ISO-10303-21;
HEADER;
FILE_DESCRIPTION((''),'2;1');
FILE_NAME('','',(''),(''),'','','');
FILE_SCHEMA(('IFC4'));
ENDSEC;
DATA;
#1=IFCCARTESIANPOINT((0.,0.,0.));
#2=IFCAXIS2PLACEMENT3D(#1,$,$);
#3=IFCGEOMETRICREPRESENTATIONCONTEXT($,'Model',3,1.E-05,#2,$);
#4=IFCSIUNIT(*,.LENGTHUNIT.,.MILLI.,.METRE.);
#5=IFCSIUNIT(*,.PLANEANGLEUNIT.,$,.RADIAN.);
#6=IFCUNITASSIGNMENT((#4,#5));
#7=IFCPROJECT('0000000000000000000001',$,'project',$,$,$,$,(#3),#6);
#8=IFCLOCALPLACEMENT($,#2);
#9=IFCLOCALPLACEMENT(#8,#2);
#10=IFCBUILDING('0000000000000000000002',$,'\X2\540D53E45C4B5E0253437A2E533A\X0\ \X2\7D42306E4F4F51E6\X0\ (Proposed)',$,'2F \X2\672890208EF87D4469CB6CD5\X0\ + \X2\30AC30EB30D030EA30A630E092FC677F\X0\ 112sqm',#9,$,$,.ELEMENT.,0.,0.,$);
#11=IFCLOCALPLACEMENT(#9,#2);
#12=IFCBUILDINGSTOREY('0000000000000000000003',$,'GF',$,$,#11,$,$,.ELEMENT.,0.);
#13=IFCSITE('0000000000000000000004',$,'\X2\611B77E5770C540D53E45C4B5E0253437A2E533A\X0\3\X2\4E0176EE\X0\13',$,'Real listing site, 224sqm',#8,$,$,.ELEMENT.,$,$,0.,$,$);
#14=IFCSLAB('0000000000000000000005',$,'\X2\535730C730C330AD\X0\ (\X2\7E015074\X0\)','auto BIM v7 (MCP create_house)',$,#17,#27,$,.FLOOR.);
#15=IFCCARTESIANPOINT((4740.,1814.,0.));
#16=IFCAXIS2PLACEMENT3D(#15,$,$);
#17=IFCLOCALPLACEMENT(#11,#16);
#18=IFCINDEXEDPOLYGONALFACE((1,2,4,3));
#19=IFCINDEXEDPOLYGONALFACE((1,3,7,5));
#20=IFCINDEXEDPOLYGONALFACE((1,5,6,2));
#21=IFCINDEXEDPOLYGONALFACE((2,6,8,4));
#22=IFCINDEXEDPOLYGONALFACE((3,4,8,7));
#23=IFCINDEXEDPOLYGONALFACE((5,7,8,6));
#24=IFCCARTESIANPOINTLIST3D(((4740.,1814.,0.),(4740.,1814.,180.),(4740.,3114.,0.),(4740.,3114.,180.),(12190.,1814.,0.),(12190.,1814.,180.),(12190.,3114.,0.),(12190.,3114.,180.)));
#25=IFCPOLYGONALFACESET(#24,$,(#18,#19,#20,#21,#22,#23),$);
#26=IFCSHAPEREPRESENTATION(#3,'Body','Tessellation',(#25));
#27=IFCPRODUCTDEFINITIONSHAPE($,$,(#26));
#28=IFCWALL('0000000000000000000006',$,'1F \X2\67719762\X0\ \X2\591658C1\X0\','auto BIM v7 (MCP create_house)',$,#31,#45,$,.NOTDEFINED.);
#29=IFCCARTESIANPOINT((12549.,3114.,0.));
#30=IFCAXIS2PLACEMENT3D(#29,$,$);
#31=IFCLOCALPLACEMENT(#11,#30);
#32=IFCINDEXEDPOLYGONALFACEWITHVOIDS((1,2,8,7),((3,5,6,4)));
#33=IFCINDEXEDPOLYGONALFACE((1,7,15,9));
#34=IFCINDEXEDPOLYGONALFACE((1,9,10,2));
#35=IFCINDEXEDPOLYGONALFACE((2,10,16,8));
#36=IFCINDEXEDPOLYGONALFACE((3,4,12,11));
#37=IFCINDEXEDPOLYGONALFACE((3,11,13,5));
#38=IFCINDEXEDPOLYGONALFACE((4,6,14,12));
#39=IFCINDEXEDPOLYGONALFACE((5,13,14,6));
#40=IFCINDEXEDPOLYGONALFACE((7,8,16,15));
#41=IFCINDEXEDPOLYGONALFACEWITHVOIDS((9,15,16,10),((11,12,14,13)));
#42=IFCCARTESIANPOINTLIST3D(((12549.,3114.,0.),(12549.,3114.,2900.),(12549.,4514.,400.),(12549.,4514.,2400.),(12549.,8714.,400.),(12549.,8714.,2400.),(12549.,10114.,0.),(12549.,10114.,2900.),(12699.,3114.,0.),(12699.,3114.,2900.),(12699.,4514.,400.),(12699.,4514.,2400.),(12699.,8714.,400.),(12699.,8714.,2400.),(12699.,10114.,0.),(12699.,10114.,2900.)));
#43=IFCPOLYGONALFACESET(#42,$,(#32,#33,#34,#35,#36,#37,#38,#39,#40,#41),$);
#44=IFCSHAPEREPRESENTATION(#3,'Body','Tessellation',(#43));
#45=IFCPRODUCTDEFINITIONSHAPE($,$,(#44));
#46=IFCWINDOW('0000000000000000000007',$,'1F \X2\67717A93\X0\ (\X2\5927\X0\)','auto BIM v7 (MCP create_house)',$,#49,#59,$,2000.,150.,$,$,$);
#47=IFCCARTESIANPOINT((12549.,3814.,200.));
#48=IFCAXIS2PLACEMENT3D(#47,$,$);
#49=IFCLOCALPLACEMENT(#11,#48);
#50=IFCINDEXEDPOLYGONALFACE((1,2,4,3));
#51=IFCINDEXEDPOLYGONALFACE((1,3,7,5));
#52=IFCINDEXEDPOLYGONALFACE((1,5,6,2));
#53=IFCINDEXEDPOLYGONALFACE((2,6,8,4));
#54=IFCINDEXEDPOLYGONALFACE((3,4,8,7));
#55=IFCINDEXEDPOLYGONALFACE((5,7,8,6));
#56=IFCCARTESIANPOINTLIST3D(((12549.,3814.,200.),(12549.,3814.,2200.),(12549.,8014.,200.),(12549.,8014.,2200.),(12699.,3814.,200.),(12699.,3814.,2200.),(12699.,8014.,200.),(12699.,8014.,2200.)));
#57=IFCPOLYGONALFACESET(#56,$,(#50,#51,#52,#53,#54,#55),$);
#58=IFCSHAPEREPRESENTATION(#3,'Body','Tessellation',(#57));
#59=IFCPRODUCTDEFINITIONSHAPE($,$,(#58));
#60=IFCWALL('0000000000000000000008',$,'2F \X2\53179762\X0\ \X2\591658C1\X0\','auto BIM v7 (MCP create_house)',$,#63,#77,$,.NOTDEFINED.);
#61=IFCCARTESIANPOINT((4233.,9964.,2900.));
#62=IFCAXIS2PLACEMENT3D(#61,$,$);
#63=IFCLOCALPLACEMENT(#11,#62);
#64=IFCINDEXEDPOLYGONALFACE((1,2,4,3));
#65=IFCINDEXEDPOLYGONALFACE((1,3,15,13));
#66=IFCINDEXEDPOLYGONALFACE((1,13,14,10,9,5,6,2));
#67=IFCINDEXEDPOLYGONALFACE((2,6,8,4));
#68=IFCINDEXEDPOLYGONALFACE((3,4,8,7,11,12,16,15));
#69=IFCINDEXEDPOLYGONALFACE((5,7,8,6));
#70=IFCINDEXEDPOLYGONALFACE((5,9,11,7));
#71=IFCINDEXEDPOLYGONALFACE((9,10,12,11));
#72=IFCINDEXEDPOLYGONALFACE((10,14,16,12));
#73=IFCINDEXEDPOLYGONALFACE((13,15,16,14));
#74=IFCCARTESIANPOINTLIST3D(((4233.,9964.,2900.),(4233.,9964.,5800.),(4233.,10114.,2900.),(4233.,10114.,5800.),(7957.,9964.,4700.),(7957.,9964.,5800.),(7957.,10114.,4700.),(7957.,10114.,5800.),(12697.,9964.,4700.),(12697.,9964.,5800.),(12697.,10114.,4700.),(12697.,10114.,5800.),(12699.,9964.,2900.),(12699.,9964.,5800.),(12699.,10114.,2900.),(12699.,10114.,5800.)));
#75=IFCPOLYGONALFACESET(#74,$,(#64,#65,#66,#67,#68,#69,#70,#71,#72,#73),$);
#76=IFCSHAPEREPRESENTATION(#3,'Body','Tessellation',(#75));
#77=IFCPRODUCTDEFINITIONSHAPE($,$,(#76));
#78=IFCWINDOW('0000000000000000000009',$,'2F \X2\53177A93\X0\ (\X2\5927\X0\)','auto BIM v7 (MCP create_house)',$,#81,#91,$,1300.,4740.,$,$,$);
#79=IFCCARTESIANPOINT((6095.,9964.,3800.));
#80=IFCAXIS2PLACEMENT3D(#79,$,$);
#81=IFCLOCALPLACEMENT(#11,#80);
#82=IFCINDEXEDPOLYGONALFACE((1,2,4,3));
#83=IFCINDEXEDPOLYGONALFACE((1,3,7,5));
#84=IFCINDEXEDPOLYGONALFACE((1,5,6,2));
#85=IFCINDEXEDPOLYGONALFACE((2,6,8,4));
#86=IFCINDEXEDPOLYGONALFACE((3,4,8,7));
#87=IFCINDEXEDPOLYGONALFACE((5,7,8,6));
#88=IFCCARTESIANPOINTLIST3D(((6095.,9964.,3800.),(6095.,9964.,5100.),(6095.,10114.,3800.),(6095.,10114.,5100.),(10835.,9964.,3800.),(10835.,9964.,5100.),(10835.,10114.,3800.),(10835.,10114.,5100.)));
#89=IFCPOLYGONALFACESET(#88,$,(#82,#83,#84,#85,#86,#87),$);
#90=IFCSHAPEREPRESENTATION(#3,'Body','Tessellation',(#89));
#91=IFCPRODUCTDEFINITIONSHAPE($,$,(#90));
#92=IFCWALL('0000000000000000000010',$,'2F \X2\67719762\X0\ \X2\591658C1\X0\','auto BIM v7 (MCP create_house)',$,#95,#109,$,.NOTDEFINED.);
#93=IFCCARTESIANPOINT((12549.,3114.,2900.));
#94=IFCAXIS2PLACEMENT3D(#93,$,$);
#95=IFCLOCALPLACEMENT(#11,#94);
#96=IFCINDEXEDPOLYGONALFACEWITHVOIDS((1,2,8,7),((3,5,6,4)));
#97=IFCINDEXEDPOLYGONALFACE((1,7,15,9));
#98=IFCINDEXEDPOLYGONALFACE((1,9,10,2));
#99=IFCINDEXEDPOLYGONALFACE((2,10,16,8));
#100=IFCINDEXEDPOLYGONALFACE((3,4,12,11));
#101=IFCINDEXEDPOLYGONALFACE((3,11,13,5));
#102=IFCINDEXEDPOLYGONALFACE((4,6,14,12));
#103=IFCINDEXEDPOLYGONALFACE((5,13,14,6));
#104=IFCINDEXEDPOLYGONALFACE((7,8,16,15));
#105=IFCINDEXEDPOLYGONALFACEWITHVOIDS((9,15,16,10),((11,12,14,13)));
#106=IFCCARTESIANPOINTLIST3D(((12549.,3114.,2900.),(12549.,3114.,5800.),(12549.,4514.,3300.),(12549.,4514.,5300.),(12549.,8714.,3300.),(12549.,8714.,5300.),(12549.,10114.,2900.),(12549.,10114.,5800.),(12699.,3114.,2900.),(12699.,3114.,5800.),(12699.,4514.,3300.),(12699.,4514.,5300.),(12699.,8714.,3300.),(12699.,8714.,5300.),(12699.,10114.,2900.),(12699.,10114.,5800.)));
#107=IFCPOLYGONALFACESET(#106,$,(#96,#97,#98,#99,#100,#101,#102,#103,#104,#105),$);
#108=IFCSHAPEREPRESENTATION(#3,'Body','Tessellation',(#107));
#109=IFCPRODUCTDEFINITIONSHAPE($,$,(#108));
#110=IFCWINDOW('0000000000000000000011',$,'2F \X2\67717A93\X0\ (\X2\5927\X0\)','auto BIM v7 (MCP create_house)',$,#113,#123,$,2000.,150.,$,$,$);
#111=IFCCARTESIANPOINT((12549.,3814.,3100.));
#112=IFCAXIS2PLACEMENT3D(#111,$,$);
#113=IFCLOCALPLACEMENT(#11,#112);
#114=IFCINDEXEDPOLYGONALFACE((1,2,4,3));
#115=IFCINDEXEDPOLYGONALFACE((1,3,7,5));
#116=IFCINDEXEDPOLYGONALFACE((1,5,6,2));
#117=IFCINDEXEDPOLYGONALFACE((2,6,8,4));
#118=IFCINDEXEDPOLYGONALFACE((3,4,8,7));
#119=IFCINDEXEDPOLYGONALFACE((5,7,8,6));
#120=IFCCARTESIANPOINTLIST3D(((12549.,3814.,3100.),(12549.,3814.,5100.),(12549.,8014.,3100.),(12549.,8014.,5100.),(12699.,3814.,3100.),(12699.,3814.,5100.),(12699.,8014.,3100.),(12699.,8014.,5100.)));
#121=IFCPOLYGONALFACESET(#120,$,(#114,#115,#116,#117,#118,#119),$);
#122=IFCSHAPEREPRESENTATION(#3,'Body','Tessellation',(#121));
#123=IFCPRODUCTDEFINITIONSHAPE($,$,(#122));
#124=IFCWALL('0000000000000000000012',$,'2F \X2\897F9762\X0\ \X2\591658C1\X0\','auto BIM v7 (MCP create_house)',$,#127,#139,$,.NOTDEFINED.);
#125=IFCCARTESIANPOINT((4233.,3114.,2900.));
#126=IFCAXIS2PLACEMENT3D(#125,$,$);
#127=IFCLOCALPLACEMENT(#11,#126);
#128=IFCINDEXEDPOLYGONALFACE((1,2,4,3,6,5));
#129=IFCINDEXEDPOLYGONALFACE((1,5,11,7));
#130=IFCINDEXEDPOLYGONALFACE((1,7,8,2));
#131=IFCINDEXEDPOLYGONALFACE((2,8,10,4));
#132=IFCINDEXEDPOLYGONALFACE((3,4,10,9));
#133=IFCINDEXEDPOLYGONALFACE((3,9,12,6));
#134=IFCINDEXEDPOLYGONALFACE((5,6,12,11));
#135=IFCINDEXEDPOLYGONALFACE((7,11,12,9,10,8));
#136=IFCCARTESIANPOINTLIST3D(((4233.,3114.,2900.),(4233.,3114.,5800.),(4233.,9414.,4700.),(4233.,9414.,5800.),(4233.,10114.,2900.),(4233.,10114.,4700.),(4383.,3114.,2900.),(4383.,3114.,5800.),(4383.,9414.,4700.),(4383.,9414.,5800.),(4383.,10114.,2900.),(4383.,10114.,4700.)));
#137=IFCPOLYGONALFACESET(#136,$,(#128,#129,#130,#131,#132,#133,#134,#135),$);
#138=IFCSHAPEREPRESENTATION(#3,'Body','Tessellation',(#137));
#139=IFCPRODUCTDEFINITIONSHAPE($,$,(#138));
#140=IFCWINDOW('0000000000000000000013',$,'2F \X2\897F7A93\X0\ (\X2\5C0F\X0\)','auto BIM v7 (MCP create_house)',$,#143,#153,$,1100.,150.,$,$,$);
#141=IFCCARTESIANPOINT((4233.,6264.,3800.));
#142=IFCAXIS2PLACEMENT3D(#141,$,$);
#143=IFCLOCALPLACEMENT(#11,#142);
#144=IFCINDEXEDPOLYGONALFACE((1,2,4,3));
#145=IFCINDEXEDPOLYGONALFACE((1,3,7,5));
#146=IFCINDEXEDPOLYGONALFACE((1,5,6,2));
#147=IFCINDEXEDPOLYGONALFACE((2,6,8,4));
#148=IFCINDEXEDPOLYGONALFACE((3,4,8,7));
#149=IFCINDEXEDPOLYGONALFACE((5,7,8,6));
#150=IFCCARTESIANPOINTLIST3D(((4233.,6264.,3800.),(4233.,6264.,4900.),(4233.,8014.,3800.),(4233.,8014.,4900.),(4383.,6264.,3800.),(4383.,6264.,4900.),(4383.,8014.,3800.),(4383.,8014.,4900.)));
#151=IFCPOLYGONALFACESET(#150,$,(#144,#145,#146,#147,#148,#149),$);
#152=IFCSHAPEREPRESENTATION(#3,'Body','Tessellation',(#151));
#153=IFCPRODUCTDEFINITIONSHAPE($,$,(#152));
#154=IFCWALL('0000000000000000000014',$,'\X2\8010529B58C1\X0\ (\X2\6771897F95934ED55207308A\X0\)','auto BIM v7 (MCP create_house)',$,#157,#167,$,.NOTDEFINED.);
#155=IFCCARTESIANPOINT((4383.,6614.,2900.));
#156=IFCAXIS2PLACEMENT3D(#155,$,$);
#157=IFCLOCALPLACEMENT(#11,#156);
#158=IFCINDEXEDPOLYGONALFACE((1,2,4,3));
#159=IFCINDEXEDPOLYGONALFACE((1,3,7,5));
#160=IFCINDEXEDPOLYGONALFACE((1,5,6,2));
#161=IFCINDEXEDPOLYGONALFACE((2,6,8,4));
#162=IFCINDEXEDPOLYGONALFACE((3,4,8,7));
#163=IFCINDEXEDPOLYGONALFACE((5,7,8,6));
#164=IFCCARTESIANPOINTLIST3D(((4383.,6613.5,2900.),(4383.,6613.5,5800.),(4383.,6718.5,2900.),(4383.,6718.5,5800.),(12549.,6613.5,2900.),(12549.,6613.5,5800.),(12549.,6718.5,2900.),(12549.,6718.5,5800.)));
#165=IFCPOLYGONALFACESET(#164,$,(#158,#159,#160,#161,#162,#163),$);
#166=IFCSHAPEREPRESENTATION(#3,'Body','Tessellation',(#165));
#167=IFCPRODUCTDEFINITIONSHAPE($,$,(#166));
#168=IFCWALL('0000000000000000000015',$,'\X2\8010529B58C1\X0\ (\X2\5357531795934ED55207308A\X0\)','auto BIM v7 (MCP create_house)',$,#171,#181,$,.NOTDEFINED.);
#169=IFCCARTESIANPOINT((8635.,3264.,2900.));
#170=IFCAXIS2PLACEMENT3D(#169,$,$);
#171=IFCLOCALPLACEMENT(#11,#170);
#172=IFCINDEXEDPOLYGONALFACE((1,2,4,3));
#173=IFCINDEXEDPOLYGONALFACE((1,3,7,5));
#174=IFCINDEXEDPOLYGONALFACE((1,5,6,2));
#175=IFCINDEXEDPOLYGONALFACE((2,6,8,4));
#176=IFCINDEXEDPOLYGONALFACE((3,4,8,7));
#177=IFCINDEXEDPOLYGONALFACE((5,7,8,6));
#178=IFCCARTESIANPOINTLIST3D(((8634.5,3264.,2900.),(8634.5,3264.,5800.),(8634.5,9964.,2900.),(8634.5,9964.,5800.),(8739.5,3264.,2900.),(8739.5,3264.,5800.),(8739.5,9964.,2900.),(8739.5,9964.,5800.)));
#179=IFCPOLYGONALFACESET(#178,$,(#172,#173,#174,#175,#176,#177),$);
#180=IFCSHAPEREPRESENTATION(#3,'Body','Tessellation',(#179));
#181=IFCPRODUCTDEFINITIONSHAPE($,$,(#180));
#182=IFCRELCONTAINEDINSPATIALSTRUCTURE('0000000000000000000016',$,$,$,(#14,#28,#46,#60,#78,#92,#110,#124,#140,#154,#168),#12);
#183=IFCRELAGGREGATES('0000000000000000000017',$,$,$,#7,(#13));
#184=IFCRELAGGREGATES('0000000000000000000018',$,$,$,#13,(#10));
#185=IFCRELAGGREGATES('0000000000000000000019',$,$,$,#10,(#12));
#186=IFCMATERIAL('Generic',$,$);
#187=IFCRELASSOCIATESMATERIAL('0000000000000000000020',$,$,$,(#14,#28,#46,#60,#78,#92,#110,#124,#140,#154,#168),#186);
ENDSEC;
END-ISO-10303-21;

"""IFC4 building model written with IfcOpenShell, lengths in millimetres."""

from ifc_helpers import new_model, si_unit, frame, frame_2d, origin, place, context, project, spatial, rectangle, extrude, material, element, fill, save


model = new_model("IFC4")

# Units and contexts
model_context = context("Model", 3, precision=1e-05, world=origin())
ifc_project = project(units=[si_unit("LENGTHUNIT", "METRE", prefix="MILLI"), si_unit("PLANEANGLEUNIT", "RADIAN")], contexts=[model_context])

# Site, building, storey
site_placement = place(None, origin())
site = spatial("IfcSite", under=ifc_project, at=site_placement, Name="愛知県名古屋市千種区3丁目13", ObjectType="Real listing site, 224sqm", CompositionType="ELEMENT", RefElevation=0.0)
building_placement = place(site_placement, origin())
building = spatial("IfcBuilding", under=site, at=building_placement, Name="名古屋市千種区 終の住処 (Proposed)", ObjectType="2F 木造軸組構法 + ガルバリウム鋼板 112sqm", CompositionType="ELEMENT", ElevationOfRefHeight=0.0, ElevationOfTerrain=0.0)
storey_placement = place(building_placement, origin())
storey = spatial("IfcBuildingStorey", under=building, at=storey_placement, Name="GF", CompositionType="ELEMENT", Elevation=0.0)

# Slab
ifc_material = material(Name="Generic")
slab_placement = place(storey_placement, frame((4740.0, 1814.0, 0.0)))
element("IfcSlab", 1, at=slab_placement, inside=storey, material=ifc_material, Name="南デッキ (縁側)", Description="auto BIM v7 (MCP create_house)", PredefinedType="FLOOR", context=model_context, shape_type="SweptSolid", body=[
    extrude(rectangle(XDim=7450.0, YDim=1300.0, at=frame_2d((3725.0, 650.0))), frame((4740.0, 1814.0, 0.0)), (0.0, 0.0, 1.0), 180.0),
])

# Wall, opening, window
wall_1_placement = place(storey_placement, frame((12549.0, 3114.0, 0.0)))
wall_1 = element("IfcWall", 2, at=wall_1_placement, inside=storey, material=ifc_material, Name="1F 東面 外壁", Description="auto BIM v7 (MCP create_house)", PredefinedType="NOTDEFINED", context=model_context, shape_type="SweptSolid", body=[
    extrude(rectangle(XDim=150.0, YDim=7000.0, at=frame_2d((75.0, 3500.0))), frame((12549.0, 3114.0, 0.0)), (0.0, 0.0, 1.0), 2900.0),
])
opening_1_placement = place(storey_placement, frame((12549.0, 3814.0, 200.0)))
opening_1 = element("IfcOpeningElement", 3, at=opening_1_placement, cuts=wall_1, PredefinedType="NOTDEFINED", context=model_context, shape_type="SweptSolid", body=[
    extrude(rectangle(XDim=150.0, YDim=4200.0, at=frame_2d((75.0, 2100.0))), frame((12549.0, 3814.0, 200.0)), (0.0, 0.0, 1.0), 2000.0),
])
window_1_placement = place(storey_placement, frame((12549.0, 3814.0, 200.0)))
window_1 = element("IfcWindow", 4, at=window_1_placement, inside=storey, material=ifc_material, Name="1F 東窓 (大)", Description="auto BIM v7 (MCP create_house)", OverallHeight=2000.0, OverallWidth=150.0, context=model_context, shape_type="SweptSolid", body=[
    extrude(rectangle(XDim=150.0, YDim=4200.0, at=frame_2d((75.0, 2100.0))), frame((12549.0, 3814.0, 200.0)), (0.0, 0.0, 1.0), 2000.0),
])
fill(opening_1, window_1)

# Walls, openings, windows
wall_2_placement = place(storey_placement, frame((4233.0, 9964.0, 2900.0)))
wall_2 = element("IfcWall", 5, at=wall_2_placement, inside=storey, material=ifc_material, Name="2F 北面 外壁", Description="auto BIM v7 (MCP create_house)", PredefinedType="NOTDEFINED", context=model_context, shape_type="SweptSolid", body=[
    extrude(rectangle(XDim=8466.0, YDim=150.0, at=frame_2d((4233.0, 75.0))), frame((4233.0, 9964.0, 2900.0)), (0.0, 0.0, 1.0), 2900.0),
])
opening_2_placement = place(storey_placement, frame((6095.0, 9964.0, 3800.0)))
opening_2 = element("IfcOpeningElement", 6, at=opening_2_placement, cuts=wall_2, PredefinedType="NOTDEFINED", context=model_context, shape_type="SweptSolid", body=[
    extrude(rectangle(XDim=4740.0, YDim=150.0, at=frame_2d((2370.0, 75.0))), frame((6095.0, 9964.0, 3800.0)), (0.0, 0.0, 1.0), 1300.0),
])
window_2_placement = place(storey_placement, frame((6095.0, 9964.0, 3800.0)))
window_2 = element("IfcWindow", 7, at=window_2_placement, inside=storey, material=ifc_material, Name="2F 北窓 (大)", Description="auto BIM v7 (MCP create_house)", OverallHeight=1300.0, OverallWidth=4740.0, context=model_context, shape_type="SweptSolid", body=[
    extrude(rectangle(XDim=4740.0, YDim=150.0, at=frame_2d((2370.0, 75.0))), frame((6095.0, 9964.0, 3800.0)), (0.0, 0.0, 1.0), 1300.0),
])
fill(opening_2, window_2)
wall_3_placement = place(storey_placement, frame((12549.0, 3114.0, 2900.0)))
wall_3 = element("IfcWall", 8, at=wall_3_placement, inside=storey, material=ifc_material, Name="2F 東面 外壁", Description="auto BIM v7 (MCP create_house)", PredefinedType="NOTDEFINED", context=model_context, shape_type="SweptSolid", body=[
    extrude(rectangle(XDim=150.0, YDim=7000.0, at=frame_2d((75.0, 3500.0))), frame((12549.0, 3114.0, 2900.0)), (0.0, 0.0, 1.0), 2900.0),
])
opening_3_placement = place(storey_placement, frame((12549.0, 3814.0, 3100.0)))
opening_3 = element("IfcOpeningElement", 9, at=opening_3_placement, cuts=wall_3, PredefinedType="NOTDEFINED", context=model_context, shape_type="SweptSolid", body=[
    extrude(rectangle(XDim=150.0, YDim=4200.0, at=frame_2d((75.0, 2100.0))), frame((12549.0, 3814.0, 3100.0)), (0.0, 0.0, 1.0), 2000.0),
])
window_3_placement = place(storey_placement, frame((12549.0, 3814.0, 3100.0)))
window_3 = element("IfcWindow", 10, at=window_3_placement, inside=storey, material=ifc_material, Name="2F 東窓 (大)", Description="auto BIM v7 (MCP create_house)", OverallHeight=2000.0, OverallWidth=150.0, context=model_context, shape_type="SweptSolid", body=[
    extrude(rectangle(XDim=150.0, YDim=4200.0, at=frame_2d((75.0, 2100.0))), frame((12549.0, 3814.0, 3100.0)), (0.0, 0.0, 1.0), 2000.0),
])
fill(opening_3, window_3)
wall_4_placement = place(storey_placement, frame((4233.0, 3114.0, 2900.0)))
wall_4 = element("IfcWall", 11, at=wall_4_placement, inside=storey, material=ifc_material, Name="2F 西面 外壁", Description="auto BIM v7 (MCP create_house)", PredefinedType="NOTDEFINED", context=model_context, shape_type="SweptSolid", body=[
    extrude(rectangle(XDim=150.0, YDim=7000.0, at=frame_2d((75.0, 3500.0))), frame((4233.0, 3114.0, 2900.0)), (0.0, 0.0, 1.0), 2900.0),
])
opening_4_placement = place(storey_placement, frame((4233.0, 6264.0, 3800.0)))
opening_4 = element("IfcOpeningElement", 12, at=opening_4_placement, cuts=wall_4, PredefinedType="NOTDEFINED", context=model_context, shape_type="SweptSolid", body=[
    extrude(rectangle(XDim=150.0, YDim=1750.0, at=frame_2d((75.0, 875.0))), frame((4233.0, 6264.0, 3800.0)), (0.0, 0.0, 1.0), 1100.0),
])
window_4_placement = place(storey_placement, frame((4233.0, 6264.0, 3800.0)))
window_4 = element("IfcWindow", 13, at=window_4_placement, inside=storey, material=ifc_material, Name="2F 西窓 (小)", Description="auto BIM v7 (MCP create_house)", OverallHeight=1100.0, OverallWidth=150.0, context=model_context, shape_type="SweptSolid", body=[
    extrude(rectangle(XDim=150.0, YDim=1750.0, at=frame_2d((75.0, 875.0))), frame((4233.0, 6264.0, 3800.0)), (0.0, 0.0, 1.0), 1100.0),
])
fill(opening_4, window_4)

# Walls
wall_5_placement = place(storey_placement, frame((4383.0, 6614.0, 2900.0)))
element("IfcWall", 14, at=wall_5_placement, inside=storey, material=ifc_material, Name="耐力壁 (東西間仕切り)", Description="auto BIM v7 (MCP create_house)", PredefinedType="NOTDEFINED", context=model_context, shape_type="SweptSolid", body=[
    extrude(rectangle(XDim=8166.0, YDim=105.0, at=frame_2d((4083.0, 52.0))), frame((4383.0, 6614.0, 2900.0)), (0.0, 0.0, 1.0), 2900.0),
])
wall_6_placement = place(storey_placement, frame((8635.0, 3264.0, 2900.0)))
element("IfcWall", 15, at=wall_6_placement, inside=storey, material=ifc_material, Name="耐力壁 (南北間仕切り)", Description="auto BIM v7 (MCP create_house)", PredefinedType="NOTDEFINED", context=model_context, shape_type="SweptSolid", body=[
    extrude(rectangle(XDim=105.0, YDim=6700.0, at=frame_2d((52.0, 3350.0))), frame((8635.0, 3264.0, 2900.0)), (0.0, 0.0, 1.0), 2900.0),
])

save(model, "model.ifc")
